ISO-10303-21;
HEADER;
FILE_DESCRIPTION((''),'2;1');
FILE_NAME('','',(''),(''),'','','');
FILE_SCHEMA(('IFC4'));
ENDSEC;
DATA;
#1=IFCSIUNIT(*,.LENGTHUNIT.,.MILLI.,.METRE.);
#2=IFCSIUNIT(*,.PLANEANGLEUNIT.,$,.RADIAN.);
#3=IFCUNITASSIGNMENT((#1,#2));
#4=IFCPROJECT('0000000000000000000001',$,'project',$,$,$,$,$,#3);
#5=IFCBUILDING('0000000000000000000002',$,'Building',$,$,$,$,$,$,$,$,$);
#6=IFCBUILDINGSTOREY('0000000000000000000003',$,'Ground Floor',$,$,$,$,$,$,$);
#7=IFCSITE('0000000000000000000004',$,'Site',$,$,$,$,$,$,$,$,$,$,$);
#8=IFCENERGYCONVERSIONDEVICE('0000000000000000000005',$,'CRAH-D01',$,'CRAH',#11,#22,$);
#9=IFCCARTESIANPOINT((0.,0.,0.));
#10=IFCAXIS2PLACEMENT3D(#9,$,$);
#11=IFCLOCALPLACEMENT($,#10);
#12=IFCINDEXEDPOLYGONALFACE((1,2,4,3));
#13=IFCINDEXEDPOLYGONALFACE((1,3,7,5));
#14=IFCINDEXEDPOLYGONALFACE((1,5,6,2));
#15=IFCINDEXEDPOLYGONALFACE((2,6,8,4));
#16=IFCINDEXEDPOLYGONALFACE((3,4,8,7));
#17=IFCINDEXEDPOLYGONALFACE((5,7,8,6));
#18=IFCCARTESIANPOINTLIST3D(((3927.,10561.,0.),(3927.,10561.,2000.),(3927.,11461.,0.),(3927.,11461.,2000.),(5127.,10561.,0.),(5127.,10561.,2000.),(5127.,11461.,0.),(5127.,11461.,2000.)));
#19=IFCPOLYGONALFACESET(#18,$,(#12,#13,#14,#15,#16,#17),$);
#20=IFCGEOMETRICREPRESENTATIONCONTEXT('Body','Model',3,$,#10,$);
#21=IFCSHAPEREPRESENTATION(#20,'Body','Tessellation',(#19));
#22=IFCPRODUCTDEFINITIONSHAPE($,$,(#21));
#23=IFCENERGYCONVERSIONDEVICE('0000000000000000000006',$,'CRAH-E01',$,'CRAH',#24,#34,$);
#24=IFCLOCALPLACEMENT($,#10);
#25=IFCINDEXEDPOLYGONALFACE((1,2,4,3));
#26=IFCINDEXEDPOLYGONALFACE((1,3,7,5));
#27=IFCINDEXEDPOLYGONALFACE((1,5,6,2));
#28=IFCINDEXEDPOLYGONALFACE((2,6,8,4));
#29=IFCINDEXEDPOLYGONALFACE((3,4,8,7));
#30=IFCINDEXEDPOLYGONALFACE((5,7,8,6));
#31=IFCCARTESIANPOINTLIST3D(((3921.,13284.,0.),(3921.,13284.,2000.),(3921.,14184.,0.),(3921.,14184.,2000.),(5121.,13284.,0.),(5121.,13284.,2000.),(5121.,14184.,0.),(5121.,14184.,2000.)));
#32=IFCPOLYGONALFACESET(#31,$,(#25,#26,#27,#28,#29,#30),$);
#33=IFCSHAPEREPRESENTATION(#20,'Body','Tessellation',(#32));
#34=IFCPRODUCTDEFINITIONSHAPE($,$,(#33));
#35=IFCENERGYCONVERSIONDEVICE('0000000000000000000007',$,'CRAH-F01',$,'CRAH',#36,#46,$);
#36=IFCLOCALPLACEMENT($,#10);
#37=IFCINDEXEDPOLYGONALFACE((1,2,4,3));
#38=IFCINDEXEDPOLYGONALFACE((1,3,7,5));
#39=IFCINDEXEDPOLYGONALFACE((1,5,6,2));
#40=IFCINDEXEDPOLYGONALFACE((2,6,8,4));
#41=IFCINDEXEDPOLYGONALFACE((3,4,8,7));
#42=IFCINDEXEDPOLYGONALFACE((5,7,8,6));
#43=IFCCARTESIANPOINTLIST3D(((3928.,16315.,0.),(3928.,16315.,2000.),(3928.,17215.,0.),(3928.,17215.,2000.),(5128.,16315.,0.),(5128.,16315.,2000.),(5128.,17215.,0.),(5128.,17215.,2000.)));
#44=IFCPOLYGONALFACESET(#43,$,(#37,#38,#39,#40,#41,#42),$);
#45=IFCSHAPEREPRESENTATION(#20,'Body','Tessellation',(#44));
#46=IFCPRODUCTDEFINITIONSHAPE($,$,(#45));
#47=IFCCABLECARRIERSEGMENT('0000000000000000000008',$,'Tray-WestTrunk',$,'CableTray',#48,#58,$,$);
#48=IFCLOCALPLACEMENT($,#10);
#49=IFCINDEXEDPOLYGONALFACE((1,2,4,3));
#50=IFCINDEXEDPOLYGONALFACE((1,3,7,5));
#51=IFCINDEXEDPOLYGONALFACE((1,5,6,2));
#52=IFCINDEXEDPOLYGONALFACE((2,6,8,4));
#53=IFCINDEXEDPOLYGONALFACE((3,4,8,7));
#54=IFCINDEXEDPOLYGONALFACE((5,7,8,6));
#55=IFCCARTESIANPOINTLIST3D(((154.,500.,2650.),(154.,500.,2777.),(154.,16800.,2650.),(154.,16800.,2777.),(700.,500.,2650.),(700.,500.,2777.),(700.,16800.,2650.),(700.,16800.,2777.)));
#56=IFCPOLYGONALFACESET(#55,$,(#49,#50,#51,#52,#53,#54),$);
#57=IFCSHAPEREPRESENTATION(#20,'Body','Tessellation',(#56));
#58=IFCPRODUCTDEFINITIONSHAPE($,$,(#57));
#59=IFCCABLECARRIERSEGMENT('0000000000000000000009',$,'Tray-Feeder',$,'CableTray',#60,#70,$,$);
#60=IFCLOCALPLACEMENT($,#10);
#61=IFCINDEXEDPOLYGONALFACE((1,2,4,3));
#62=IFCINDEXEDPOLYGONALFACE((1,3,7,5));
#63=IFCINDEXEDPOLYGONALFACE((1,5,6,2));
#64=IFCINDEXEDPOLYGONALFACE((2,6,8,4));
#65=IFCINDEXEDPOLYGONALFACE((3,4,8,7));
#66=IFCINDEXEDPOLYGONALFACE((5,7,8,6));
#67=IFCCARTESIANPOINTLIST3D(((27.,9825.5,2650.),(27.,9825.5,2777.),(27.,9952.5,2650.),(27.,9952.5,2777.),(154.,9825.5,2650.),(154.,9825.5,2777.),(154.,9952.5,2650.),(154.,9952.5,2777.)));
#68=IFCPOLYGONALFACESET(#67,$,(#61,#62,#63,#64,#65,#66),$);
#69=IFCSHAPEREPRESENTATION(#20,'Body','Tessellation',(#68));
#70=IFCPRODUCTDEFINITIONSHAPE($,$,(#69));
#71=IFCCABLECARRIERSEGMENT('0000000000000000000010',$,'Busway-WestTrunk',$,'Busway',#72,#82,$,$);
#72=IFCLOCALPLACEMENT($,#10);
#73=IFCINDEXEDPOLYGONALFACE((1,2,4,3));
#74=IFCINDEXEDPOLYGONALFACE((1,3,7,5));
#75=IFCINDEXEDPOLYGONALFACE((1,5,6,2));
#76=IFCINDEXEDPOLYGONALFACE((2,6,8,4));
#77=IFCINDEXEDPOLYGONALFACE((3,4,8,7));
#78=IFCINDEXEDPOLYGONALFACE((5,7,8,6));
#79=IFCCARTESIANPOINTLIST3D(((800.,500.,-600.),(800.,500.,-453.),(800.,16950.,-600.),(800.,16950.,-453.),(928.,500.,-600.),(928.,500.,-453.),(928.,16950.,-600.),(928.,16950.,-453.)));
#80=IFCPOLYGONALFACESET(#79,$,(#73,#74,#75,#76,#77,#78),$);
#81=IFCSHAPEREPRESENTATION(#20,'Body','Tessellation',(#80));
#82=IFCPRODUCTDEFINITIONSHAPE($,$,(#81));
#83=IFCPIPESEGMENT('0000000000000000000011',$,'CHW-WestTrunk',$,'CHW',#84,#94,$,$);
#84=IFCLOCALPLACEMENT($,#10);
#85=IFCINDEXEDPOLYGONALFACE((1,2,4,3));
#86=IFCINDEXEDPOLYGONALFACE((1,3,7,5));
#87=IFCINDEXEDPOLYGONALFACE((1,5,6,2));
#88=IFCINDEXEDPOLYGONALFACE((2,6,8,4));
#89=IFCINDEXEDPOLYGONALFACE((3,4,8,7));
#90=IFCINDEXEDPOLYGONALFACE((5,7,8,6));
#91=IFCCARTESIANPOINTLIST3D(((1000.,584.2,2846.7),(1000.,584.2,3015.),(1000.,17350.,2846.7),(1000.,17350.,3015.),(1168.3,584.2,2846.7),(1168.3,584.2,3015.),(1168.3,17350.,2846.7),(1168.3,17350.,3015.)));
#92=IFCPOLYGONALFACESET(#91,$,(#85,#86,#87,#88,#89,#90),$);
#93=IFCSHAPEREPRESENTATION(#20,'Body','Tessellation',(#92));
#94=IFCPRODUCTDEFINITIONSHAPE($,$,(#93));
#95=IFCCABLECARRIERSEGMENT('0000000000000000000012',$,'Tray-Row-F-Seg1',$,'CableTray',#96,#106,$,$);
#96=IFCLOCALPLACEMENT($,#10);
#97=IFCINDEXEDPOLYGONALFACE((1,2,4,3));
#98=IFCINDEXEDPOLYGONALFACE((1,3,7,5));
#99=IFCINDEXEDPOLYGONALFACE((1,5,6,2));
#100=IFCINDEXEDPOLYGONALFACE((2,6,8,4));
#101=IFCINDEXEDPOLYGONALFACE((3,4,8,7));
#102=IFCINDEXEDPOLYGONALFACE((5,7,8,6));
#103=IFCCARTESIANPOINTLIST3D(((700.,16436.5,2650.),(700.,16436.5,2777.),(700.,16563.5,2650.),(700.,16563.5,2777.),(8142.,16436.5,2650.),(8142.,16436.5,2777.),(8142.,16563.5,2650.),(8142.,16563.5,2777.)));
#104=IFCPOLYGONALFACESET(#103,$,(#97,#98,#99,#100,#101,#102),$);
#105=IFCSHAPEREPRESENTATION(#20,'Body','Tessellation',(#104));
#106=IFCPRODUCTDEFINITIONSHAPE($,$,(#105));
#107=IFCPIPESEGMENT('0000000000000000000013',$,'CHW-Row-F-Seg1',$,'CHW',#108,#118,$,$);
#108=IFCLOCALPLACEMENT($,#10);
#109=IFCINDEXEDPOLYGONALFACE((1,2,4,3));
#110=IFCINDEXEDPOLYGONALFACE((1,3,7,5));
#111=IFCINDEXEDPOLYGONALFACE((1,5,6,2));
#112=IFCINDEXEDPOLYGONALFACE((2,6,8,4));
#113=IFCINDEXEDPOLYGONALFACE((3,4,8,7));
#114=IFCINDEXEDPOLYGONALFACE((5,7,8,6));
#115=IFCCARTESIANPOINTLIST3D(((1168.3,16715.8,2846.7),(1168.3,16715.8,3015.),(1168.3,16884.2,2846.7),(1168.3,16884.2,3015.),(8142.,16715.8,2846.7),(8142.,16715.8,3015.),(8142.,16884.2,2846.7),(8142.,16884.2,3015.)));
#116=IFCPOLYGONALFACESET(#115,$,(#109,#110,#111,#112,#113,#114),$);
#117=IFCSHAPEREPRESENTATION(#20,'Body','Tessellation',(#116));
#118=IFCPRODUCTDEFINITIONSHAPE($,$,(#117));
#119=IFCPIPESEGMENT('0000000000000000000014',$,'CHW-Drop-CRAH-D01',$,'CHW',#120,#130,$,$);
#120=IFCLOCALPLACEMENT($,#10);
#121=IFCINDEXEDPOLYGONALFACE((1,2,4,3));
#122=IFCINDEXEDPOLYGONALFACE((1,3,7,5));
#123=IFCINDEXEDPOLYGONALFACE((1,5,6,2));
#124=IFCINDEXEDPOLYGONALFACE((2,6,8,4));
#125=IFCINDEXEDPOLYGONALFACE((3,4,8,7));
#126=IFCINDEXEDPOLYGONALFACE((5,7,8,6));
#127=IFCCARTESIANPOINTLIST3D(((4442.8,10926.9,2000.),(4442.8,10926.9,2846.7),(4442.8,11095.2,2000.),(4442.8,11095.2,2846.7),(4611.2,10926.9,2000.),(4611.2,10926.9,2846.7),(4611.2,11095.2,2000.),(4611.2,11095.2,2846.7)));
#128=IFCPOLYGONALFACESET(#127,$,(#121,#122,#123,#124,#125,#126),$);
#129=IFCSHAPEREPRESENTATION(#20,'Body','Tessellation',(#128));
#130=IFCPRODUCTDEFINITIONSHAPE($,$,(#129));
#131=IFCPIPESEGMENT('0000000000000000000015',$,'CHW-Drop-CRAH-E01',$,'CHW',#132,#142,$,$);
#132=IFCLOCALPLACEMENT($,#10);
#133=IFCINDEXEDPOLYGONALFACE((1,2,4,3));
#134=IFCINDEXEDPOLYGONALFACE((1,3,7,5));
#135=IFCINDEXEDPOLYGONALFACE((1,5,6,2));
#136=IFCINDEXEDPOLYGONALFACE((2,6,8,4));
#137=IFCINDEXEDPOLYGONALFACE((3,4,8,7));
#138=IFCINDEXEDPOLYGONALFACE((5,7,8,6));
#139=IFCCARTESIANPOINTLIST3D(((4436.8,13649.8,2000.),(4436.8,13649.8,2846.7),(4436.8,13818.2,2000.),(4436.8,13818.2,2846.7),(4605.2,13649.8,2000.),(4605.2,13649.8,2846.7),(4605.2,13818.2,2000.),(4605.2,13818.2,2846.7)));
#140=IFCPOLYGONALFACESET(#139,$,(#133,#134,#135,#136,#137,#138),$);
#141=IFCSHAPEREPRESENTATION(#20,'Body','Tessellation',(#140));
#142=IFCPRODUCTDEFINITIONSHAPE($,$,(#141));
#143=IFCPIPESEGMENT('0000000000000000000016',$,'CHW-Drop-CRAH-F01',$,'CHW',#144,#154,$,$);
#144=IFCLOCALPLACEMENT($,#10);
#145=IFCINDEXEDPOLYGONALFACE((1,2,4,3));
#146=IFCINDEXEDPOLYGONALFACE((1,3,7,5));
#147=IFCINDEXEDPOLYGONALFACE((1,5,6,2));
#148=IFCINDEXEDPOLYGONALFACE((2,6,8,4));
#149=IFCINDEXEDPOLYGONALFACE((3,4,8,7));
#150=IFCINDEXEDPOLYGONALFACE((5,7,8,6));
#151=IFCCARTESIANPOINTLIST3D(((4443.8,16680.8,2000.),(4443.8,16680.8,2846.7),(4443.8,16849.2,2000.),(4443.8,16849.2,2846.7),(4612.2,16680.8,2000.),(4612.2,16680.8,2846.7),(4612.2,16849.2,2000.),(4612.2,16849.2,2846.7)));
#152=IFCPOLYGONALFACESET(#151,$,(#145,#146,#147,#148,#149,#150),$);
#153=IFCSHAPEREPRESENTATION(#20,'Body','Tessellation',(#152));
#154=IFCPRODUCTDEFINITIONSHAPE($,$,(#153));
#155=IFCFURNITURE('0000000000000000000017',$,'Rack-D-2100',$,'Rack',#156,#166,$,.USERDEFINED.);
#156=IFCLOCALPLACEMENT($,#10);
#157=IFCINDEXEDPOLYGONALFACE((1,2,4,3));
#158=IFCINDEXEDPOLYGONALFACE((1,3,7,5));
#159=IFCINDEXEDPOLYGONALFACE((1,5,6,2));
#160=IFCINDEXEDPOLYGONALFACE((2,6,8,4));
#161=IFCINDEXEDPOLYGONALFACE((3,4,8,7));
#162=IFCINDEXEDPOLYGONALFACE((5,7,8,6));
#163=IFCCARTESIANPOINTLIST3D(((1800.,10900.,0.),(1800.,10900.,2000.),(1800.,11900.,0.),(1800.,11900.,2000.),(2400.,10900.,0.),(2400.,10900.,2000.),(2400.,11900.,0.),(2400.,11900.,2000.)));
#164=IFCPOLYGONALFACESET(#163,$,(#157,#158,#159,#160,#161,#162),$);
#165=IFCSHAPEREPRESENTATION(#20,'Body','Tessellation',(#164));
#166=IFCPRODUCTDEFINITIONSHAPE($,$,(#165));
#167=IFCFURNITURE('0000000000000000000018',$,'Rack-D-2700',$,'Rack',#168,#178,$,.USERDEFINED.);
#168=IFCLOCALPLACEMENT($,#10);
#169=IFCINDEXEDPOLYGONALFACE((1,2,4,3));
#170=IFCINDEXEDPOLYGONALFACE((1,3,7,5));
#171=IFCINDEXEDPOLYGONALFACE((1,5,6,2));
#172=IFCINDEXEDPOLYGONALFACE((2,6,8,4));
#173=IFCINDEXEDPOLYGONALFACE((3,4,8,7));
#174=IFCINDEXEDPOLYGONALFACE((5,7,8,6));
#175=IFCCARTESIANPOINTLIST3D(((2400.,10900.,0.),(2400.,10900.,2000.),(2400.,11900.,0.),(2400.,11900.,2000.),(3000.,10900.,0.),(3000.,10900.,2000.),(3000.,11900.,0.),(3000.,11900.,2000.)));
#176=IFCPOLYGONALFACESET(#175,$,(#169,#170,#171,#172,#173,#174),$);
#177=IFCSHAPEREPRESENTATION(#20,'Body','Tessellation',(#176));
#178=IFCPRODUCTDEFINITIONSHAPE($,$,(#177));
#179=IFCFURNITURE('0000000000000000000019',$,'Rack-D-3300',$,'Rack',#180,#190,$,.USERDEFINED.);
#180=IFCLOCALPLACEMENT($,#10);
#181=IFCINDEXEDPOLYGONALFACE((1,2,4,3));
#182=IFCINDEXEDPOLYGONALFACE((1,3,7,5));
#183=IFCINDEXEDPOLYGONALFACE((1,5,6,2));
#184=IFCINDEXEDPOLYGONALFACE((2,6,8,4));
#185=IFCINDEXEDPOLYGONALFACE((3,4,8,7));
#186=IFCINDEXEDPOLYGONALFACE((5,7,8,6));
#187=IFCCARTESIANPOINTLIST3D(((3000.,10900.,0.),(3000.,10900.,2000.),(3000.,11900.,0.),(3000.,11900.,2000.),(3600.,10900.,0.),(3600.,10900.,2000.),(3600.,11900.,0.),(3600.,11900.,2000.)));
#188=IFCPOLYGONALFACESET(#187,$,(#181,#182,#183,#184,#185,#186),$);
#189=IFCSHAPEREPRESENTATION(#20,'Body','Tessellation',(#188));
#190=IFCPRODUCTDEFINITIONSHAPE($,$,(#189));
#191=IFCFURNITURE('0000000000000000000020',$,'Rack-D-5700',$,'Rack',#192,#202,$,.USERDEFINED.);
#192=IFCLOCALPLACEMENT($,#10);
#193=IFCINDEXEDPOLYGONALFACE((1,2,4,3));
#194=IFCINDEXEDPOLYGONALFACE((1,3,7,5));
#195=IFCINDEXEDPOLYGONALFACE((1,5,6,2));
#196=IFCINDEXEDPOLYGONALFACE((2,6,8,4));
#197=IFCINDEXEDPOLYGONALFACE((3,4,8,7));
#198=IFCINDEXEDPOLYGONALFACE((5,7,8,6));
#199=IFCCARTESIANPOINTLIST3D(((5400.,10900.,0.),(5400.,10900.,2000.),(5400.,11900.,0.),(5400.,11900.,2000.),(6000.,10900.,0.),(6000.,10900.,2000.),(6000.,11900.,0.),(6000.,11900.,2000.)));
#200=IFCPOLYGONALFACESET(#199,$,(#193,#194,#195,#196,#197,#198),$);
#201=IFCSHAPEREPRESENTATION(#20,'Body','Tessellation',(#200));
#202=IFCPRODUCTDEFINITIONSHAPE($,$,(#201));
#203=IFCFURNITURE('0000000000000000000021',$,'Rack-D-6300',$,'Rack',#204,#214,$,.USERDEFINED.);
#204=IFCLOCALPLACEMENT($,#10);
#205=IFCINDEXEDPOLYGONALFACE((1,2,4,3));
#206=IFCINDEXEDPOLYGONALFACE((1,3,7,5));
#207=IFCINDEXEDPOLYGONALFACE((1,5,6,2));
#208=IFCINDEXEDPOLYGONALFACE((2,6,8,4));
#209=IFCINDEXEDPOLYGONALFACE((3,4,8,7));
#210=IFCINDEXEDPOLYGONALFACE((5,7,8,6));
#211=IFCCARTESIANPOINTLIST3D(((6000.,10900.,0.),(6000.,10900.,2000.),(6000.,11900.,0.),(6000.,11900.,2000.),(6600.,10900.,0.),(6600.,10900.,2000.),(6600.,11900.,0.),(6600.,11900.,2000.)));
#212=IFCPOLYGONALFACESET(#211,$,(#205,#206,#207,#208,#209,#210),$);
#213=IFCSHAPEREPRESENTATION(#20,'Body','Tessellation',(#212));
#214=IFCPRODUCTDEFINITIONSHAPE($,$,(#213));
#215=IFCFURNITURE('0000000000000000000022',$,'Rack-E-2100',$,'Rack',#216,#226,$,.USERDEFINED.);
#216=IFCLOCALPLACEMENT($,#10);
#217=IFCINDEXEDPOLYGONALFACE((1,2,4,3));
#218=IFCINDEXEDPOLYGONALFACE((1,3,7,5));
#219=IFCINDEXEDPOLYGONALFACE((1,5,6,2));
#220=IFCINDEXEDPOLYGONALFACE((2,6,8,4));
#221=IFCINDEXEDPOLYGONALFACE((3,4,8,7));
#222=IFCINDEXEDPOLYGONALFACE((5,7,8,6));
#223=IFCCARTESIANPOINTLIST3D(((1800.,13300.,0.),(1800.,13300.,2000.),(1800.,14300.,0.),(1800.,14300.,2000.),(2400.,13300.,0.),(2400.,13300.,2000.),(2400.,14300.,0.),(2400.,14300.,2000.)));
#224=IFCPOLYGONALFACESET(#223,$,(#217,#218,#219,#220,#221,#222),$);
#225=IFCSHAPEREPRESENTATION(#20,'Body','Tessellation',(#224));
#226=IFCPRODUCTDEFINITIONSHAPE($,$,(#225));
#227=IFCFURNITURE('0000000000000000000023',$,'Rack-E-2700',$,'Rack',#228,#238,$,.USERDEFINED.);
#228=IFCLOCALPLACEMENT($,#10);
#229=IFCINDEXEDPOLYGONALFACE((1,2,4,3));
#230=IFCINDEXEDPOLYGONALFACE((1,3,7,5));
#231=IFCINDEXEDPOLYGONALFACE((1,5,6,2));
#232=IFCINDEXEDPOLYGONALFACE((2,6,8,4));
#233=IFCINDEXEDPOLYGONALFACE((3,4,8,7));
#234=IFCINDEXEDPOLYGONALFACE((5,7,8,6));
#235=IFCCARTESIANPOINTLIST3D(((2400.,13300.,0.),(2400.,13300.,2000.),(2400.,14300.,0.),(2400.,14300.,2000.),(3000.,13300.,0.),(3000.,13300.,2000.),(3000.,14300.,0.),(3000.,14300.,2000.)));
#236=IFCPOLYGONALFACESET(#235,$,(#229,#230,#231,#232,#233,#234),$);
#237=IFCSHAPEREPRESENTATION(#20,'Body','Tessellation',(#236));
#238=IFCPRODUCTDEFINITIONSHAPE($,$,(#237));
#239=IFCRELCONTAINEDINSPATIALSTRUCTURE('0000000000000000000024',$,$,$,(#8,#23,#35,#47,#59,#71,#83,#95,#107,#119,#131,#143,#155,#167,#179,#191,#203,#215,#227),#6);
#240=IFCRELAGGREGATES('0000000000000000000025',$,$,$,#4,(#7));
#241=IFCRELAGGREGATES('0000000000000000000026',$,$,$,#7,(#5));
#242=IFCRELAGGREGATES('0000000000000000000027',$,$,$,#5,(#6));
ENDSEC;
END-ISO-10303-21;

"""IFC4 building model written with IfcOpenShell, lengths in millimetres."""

from ifc_helpers import new_model, si_unit, frame, origin, place, context, project, spatial, rectangle, extrude, element, save


model = new_model("IFC4")

# Units and contexts
model_context = context("Model", 3, world=origin(), identifier="Body")
ifc_project = project(units=[si_unit("LENGTHUNIT", "METRE", prefix="MILLI"), si_unit("PLANEANGLEUNIT", "RADIAN")])

# Site, building, storey
site = spatial("IfcSite", under=ifc_project, Name="Site")
building = spatial("IfcBuilding", under=site, Name="Building")
storey = spatial("IfcBuildingStorey", under=building, Name="Ground Floor")

# Energy conversion devices
for number, where, z_axis, x_axis, name in (
    (1, (4527.0, 11011.0, 0.0), (0.0, 0.0, 1.0), (1.0, 0.0, 0.0), "CRAH-D01"),
    (2, (4521.0, 13734.0, 0.0), (0.0, 0.0, 1.0), (1.0, 0.0, 0.0), "CRAH-E01"),
    (3, (4528.0, 16765.0, 0.0), (0.0, 0.0, 1.0), (1.0, 0.0, 0.0), "CRAH-F01"),
):
    element("IfcEnergyConversionDevice", number, at=place(None, frame(where, z_axis=z_axis, x_axis=x_axis)), inside=storey, Name=name, ObjectType="CRAH", context=model_context, shape_type="SweptSolid", body=[
        extrude(rectangle(XDim=1200.0, YDim=900.0), origin(), (0.0, 0.0, 1.0), 2000.0),
    ])

# Cable carrier segments
cable_carrier_segment_1_placement = place(None, frame((427.0, 8650.0, 2650.0), z_axis=(0.0, 0.0, 1.0), x_axis=(1.0, 0.0, 0.0)))
element("IfcCableCarrierSegment", 4, at=cable_carrier_segment_1_placement, inside=storey, Name="Tray-WestTrunk", ObjectType="CableTray", context=model_context, shape_type="SweptSolid", body=[
    extrude(rectangle(XDim=546.0, YDim=16300.0), origin(), (0.0, 0.0, 1.0), 127.0),
])
cable_carrier_segment_2_placement = place(None, frame((90.5, 9889.0, 2650.0), z_axis=(0.0, 0.0, 1.0), x_axis=(1.0, 0.0, 0.0)))
element("IfcCableCarrierSegment", 5, at=cable_carrier_segment_2_placement, inside=storey, Name="Tray-Feeder", ObjectType="CableTray", context=model_context, shape_type="SweptSolid", body=[
    extrude(rectangle(XDim=127.0, YDim=127.0), origin(), (0.0, 0.0, 1.0), 127.0),
])
cable_carrier_segment_3_placement = place(None, frame((864.0, 8725.0, -600.0), z_axis=(0.0, 0.0, 1.0), x_axis=(1.0, 0.0, 0.0)))
element("IfcCableCarrierSegment", 6, at=cable_carrier_segment_3_placement, inside=storey, Name="Busway-WestTrunk", ObjectType="Busway", context=model_context, shape_type="SweptSolid", body=[
    extrude(rectangle(XDim=128.0, YDim=16450.0), origin(), (0.0, 0.0, 1.0), 147.0),
])

# Pipe segment
pipe_segment_1_placement = place(None, frame((1084.2, 8967.1, 2846.7), z_axis=(0.0, 0.0, 1.0), x_axis=(1.0, 0.0, 0.0)))
element("IfcPipeSegment", 7, at=pipe_segment_1_placement, inside=storey, Name="CHW-WestTrunk", ObjectType="CHW", context=model_context, shape_type="SweptSolid", body=[
    extrude(rectangle(XDim=168.3, YDim=16765.8), origin(), (0.0, 0.0, 1.0), 168.3),
])

# Cable carrier segment
cable_carrier_segment_4_placement = place(None, frame((4421.0, 16500.0, 2650.0), z_axis=(0.0, 0.0, 1.0), x_axis=(1.0, 0.0, 0.0)))
element("IfcCableCarrierSegment", 8, at=cable_carrier_segment_4_placement, inside=storey, Name="Tray-Row-F-Seg1", ObjectType="CableTray", context=model_context, shape_type="SweptSolid", body=[
    extrude(rectangle(XDim=7442.0, YDim=127.0), origin(), (0.0, 0.0, 1.0), 127.0),
])

# Pipe segments
pipe_segment_2_placement = place(None, frame((4655.1, 16800.0, 2846.7), z_axis=(0.0, 0.0, 1.0), x_axis=(1.0, 0.0, 0.0)))
element("IfcPipeSegment", 9, at=pipe_segment_2_placement, inside=storey, Name="CHW-Row-F-Seg1", ObjectType="CHW", context=model_context, shape_type="SweptSolid", body=[
    extrude(rectangle(XDim=6973.7, YDim=168.3), origin(), (0.0, 0.0, 1.0), 168.3),
])
for number, where, z_axis, x_axis, name in (
    (10, (4527.0, 11011.0, 2000.0), (0.0, 0.0, 1.0), (1.0, 0.0, 0.0), "CHW-Drop-CRAH-D01"),
    (11, (4521.0, 13734.0, 2000.0), (0.0, 0.0, 1.0), (1.0, 0.0, 0.0), "CHW-Drop-CRAH-E01"),
    (12, (4528.0, 16765.0, 2000.0), (0.0, 0.0, 1.0), (1.0, 0.0, 0.0), "CHW-Drop-CRAH-F01"),
):
    element("IfcPipeSegment", number, at=place(None, frame(where, z_axis=z_axis, x_axis=x_axis)), inside=storey, Name=name, ObjectType="CHW", context=model_context, shape_type="SweptSolid", body=[
        extrude(rectangle(XDim=168.3, YDim=168.3), origin(), (0.0, 0.0, 1.0), 846.7),
    ])

# Furniture
for number, where, z_axis, x_axis, name in (
    (13, (2100.0, 11400.0, 0.0), (0.0, 0.0, 1.0), (1.0, 0.0, 0.0), "Rack-D-2100"),
    (14, (2700.0, 11400.0, 0.0), (0.0, 0.0, 1.0), (1.0, 0.0, 0.0), "Rack-D-2700"),
    (15, (3300.0, 11400.0, 0.0), (0.0, 0.0, 1.0), (1.0, 0.0, 0.0), "Rack-D-3300"),
    (16, (5700.0, 11400.0, 0.0), (0.0, 0.0, 1.0), (1.0, 0.0, 0.0), "Rack-D-5700"),
    (17, (6300.0, 11400.0, 0.0), (0.0, 0.0, 1.0), (1.0, 0.0, 0.0), "Rack-D-6300"),
    (18, (2100.0, 13800.0, 0.0), (0.0, 0.0, 1.0), (1.0, 0.0, 0.0), "Rack-E-2100"),
    (19, (2700.0, 13800.0, 0.0), (0.0, 0.0, 1.0), (1.0, 0.0, 0.0), "Rack-E-2700"),
):
    element("IfcFurniture", number, at=place(None, frame(where, z_axis=z_axis, x_axis=x_axis)), inside=storey, Name=name, ObjectType="Rack", PredefinedType="USERDEFINED", context=model_context, shape_type="SweptSolid", body=[
        extrude(rectangle(XDim=600.0, YDim=1000.0), origin(), (0.0, 0.0, 1.0), 2000.0),
    ])

save(model, "model.ifc")
